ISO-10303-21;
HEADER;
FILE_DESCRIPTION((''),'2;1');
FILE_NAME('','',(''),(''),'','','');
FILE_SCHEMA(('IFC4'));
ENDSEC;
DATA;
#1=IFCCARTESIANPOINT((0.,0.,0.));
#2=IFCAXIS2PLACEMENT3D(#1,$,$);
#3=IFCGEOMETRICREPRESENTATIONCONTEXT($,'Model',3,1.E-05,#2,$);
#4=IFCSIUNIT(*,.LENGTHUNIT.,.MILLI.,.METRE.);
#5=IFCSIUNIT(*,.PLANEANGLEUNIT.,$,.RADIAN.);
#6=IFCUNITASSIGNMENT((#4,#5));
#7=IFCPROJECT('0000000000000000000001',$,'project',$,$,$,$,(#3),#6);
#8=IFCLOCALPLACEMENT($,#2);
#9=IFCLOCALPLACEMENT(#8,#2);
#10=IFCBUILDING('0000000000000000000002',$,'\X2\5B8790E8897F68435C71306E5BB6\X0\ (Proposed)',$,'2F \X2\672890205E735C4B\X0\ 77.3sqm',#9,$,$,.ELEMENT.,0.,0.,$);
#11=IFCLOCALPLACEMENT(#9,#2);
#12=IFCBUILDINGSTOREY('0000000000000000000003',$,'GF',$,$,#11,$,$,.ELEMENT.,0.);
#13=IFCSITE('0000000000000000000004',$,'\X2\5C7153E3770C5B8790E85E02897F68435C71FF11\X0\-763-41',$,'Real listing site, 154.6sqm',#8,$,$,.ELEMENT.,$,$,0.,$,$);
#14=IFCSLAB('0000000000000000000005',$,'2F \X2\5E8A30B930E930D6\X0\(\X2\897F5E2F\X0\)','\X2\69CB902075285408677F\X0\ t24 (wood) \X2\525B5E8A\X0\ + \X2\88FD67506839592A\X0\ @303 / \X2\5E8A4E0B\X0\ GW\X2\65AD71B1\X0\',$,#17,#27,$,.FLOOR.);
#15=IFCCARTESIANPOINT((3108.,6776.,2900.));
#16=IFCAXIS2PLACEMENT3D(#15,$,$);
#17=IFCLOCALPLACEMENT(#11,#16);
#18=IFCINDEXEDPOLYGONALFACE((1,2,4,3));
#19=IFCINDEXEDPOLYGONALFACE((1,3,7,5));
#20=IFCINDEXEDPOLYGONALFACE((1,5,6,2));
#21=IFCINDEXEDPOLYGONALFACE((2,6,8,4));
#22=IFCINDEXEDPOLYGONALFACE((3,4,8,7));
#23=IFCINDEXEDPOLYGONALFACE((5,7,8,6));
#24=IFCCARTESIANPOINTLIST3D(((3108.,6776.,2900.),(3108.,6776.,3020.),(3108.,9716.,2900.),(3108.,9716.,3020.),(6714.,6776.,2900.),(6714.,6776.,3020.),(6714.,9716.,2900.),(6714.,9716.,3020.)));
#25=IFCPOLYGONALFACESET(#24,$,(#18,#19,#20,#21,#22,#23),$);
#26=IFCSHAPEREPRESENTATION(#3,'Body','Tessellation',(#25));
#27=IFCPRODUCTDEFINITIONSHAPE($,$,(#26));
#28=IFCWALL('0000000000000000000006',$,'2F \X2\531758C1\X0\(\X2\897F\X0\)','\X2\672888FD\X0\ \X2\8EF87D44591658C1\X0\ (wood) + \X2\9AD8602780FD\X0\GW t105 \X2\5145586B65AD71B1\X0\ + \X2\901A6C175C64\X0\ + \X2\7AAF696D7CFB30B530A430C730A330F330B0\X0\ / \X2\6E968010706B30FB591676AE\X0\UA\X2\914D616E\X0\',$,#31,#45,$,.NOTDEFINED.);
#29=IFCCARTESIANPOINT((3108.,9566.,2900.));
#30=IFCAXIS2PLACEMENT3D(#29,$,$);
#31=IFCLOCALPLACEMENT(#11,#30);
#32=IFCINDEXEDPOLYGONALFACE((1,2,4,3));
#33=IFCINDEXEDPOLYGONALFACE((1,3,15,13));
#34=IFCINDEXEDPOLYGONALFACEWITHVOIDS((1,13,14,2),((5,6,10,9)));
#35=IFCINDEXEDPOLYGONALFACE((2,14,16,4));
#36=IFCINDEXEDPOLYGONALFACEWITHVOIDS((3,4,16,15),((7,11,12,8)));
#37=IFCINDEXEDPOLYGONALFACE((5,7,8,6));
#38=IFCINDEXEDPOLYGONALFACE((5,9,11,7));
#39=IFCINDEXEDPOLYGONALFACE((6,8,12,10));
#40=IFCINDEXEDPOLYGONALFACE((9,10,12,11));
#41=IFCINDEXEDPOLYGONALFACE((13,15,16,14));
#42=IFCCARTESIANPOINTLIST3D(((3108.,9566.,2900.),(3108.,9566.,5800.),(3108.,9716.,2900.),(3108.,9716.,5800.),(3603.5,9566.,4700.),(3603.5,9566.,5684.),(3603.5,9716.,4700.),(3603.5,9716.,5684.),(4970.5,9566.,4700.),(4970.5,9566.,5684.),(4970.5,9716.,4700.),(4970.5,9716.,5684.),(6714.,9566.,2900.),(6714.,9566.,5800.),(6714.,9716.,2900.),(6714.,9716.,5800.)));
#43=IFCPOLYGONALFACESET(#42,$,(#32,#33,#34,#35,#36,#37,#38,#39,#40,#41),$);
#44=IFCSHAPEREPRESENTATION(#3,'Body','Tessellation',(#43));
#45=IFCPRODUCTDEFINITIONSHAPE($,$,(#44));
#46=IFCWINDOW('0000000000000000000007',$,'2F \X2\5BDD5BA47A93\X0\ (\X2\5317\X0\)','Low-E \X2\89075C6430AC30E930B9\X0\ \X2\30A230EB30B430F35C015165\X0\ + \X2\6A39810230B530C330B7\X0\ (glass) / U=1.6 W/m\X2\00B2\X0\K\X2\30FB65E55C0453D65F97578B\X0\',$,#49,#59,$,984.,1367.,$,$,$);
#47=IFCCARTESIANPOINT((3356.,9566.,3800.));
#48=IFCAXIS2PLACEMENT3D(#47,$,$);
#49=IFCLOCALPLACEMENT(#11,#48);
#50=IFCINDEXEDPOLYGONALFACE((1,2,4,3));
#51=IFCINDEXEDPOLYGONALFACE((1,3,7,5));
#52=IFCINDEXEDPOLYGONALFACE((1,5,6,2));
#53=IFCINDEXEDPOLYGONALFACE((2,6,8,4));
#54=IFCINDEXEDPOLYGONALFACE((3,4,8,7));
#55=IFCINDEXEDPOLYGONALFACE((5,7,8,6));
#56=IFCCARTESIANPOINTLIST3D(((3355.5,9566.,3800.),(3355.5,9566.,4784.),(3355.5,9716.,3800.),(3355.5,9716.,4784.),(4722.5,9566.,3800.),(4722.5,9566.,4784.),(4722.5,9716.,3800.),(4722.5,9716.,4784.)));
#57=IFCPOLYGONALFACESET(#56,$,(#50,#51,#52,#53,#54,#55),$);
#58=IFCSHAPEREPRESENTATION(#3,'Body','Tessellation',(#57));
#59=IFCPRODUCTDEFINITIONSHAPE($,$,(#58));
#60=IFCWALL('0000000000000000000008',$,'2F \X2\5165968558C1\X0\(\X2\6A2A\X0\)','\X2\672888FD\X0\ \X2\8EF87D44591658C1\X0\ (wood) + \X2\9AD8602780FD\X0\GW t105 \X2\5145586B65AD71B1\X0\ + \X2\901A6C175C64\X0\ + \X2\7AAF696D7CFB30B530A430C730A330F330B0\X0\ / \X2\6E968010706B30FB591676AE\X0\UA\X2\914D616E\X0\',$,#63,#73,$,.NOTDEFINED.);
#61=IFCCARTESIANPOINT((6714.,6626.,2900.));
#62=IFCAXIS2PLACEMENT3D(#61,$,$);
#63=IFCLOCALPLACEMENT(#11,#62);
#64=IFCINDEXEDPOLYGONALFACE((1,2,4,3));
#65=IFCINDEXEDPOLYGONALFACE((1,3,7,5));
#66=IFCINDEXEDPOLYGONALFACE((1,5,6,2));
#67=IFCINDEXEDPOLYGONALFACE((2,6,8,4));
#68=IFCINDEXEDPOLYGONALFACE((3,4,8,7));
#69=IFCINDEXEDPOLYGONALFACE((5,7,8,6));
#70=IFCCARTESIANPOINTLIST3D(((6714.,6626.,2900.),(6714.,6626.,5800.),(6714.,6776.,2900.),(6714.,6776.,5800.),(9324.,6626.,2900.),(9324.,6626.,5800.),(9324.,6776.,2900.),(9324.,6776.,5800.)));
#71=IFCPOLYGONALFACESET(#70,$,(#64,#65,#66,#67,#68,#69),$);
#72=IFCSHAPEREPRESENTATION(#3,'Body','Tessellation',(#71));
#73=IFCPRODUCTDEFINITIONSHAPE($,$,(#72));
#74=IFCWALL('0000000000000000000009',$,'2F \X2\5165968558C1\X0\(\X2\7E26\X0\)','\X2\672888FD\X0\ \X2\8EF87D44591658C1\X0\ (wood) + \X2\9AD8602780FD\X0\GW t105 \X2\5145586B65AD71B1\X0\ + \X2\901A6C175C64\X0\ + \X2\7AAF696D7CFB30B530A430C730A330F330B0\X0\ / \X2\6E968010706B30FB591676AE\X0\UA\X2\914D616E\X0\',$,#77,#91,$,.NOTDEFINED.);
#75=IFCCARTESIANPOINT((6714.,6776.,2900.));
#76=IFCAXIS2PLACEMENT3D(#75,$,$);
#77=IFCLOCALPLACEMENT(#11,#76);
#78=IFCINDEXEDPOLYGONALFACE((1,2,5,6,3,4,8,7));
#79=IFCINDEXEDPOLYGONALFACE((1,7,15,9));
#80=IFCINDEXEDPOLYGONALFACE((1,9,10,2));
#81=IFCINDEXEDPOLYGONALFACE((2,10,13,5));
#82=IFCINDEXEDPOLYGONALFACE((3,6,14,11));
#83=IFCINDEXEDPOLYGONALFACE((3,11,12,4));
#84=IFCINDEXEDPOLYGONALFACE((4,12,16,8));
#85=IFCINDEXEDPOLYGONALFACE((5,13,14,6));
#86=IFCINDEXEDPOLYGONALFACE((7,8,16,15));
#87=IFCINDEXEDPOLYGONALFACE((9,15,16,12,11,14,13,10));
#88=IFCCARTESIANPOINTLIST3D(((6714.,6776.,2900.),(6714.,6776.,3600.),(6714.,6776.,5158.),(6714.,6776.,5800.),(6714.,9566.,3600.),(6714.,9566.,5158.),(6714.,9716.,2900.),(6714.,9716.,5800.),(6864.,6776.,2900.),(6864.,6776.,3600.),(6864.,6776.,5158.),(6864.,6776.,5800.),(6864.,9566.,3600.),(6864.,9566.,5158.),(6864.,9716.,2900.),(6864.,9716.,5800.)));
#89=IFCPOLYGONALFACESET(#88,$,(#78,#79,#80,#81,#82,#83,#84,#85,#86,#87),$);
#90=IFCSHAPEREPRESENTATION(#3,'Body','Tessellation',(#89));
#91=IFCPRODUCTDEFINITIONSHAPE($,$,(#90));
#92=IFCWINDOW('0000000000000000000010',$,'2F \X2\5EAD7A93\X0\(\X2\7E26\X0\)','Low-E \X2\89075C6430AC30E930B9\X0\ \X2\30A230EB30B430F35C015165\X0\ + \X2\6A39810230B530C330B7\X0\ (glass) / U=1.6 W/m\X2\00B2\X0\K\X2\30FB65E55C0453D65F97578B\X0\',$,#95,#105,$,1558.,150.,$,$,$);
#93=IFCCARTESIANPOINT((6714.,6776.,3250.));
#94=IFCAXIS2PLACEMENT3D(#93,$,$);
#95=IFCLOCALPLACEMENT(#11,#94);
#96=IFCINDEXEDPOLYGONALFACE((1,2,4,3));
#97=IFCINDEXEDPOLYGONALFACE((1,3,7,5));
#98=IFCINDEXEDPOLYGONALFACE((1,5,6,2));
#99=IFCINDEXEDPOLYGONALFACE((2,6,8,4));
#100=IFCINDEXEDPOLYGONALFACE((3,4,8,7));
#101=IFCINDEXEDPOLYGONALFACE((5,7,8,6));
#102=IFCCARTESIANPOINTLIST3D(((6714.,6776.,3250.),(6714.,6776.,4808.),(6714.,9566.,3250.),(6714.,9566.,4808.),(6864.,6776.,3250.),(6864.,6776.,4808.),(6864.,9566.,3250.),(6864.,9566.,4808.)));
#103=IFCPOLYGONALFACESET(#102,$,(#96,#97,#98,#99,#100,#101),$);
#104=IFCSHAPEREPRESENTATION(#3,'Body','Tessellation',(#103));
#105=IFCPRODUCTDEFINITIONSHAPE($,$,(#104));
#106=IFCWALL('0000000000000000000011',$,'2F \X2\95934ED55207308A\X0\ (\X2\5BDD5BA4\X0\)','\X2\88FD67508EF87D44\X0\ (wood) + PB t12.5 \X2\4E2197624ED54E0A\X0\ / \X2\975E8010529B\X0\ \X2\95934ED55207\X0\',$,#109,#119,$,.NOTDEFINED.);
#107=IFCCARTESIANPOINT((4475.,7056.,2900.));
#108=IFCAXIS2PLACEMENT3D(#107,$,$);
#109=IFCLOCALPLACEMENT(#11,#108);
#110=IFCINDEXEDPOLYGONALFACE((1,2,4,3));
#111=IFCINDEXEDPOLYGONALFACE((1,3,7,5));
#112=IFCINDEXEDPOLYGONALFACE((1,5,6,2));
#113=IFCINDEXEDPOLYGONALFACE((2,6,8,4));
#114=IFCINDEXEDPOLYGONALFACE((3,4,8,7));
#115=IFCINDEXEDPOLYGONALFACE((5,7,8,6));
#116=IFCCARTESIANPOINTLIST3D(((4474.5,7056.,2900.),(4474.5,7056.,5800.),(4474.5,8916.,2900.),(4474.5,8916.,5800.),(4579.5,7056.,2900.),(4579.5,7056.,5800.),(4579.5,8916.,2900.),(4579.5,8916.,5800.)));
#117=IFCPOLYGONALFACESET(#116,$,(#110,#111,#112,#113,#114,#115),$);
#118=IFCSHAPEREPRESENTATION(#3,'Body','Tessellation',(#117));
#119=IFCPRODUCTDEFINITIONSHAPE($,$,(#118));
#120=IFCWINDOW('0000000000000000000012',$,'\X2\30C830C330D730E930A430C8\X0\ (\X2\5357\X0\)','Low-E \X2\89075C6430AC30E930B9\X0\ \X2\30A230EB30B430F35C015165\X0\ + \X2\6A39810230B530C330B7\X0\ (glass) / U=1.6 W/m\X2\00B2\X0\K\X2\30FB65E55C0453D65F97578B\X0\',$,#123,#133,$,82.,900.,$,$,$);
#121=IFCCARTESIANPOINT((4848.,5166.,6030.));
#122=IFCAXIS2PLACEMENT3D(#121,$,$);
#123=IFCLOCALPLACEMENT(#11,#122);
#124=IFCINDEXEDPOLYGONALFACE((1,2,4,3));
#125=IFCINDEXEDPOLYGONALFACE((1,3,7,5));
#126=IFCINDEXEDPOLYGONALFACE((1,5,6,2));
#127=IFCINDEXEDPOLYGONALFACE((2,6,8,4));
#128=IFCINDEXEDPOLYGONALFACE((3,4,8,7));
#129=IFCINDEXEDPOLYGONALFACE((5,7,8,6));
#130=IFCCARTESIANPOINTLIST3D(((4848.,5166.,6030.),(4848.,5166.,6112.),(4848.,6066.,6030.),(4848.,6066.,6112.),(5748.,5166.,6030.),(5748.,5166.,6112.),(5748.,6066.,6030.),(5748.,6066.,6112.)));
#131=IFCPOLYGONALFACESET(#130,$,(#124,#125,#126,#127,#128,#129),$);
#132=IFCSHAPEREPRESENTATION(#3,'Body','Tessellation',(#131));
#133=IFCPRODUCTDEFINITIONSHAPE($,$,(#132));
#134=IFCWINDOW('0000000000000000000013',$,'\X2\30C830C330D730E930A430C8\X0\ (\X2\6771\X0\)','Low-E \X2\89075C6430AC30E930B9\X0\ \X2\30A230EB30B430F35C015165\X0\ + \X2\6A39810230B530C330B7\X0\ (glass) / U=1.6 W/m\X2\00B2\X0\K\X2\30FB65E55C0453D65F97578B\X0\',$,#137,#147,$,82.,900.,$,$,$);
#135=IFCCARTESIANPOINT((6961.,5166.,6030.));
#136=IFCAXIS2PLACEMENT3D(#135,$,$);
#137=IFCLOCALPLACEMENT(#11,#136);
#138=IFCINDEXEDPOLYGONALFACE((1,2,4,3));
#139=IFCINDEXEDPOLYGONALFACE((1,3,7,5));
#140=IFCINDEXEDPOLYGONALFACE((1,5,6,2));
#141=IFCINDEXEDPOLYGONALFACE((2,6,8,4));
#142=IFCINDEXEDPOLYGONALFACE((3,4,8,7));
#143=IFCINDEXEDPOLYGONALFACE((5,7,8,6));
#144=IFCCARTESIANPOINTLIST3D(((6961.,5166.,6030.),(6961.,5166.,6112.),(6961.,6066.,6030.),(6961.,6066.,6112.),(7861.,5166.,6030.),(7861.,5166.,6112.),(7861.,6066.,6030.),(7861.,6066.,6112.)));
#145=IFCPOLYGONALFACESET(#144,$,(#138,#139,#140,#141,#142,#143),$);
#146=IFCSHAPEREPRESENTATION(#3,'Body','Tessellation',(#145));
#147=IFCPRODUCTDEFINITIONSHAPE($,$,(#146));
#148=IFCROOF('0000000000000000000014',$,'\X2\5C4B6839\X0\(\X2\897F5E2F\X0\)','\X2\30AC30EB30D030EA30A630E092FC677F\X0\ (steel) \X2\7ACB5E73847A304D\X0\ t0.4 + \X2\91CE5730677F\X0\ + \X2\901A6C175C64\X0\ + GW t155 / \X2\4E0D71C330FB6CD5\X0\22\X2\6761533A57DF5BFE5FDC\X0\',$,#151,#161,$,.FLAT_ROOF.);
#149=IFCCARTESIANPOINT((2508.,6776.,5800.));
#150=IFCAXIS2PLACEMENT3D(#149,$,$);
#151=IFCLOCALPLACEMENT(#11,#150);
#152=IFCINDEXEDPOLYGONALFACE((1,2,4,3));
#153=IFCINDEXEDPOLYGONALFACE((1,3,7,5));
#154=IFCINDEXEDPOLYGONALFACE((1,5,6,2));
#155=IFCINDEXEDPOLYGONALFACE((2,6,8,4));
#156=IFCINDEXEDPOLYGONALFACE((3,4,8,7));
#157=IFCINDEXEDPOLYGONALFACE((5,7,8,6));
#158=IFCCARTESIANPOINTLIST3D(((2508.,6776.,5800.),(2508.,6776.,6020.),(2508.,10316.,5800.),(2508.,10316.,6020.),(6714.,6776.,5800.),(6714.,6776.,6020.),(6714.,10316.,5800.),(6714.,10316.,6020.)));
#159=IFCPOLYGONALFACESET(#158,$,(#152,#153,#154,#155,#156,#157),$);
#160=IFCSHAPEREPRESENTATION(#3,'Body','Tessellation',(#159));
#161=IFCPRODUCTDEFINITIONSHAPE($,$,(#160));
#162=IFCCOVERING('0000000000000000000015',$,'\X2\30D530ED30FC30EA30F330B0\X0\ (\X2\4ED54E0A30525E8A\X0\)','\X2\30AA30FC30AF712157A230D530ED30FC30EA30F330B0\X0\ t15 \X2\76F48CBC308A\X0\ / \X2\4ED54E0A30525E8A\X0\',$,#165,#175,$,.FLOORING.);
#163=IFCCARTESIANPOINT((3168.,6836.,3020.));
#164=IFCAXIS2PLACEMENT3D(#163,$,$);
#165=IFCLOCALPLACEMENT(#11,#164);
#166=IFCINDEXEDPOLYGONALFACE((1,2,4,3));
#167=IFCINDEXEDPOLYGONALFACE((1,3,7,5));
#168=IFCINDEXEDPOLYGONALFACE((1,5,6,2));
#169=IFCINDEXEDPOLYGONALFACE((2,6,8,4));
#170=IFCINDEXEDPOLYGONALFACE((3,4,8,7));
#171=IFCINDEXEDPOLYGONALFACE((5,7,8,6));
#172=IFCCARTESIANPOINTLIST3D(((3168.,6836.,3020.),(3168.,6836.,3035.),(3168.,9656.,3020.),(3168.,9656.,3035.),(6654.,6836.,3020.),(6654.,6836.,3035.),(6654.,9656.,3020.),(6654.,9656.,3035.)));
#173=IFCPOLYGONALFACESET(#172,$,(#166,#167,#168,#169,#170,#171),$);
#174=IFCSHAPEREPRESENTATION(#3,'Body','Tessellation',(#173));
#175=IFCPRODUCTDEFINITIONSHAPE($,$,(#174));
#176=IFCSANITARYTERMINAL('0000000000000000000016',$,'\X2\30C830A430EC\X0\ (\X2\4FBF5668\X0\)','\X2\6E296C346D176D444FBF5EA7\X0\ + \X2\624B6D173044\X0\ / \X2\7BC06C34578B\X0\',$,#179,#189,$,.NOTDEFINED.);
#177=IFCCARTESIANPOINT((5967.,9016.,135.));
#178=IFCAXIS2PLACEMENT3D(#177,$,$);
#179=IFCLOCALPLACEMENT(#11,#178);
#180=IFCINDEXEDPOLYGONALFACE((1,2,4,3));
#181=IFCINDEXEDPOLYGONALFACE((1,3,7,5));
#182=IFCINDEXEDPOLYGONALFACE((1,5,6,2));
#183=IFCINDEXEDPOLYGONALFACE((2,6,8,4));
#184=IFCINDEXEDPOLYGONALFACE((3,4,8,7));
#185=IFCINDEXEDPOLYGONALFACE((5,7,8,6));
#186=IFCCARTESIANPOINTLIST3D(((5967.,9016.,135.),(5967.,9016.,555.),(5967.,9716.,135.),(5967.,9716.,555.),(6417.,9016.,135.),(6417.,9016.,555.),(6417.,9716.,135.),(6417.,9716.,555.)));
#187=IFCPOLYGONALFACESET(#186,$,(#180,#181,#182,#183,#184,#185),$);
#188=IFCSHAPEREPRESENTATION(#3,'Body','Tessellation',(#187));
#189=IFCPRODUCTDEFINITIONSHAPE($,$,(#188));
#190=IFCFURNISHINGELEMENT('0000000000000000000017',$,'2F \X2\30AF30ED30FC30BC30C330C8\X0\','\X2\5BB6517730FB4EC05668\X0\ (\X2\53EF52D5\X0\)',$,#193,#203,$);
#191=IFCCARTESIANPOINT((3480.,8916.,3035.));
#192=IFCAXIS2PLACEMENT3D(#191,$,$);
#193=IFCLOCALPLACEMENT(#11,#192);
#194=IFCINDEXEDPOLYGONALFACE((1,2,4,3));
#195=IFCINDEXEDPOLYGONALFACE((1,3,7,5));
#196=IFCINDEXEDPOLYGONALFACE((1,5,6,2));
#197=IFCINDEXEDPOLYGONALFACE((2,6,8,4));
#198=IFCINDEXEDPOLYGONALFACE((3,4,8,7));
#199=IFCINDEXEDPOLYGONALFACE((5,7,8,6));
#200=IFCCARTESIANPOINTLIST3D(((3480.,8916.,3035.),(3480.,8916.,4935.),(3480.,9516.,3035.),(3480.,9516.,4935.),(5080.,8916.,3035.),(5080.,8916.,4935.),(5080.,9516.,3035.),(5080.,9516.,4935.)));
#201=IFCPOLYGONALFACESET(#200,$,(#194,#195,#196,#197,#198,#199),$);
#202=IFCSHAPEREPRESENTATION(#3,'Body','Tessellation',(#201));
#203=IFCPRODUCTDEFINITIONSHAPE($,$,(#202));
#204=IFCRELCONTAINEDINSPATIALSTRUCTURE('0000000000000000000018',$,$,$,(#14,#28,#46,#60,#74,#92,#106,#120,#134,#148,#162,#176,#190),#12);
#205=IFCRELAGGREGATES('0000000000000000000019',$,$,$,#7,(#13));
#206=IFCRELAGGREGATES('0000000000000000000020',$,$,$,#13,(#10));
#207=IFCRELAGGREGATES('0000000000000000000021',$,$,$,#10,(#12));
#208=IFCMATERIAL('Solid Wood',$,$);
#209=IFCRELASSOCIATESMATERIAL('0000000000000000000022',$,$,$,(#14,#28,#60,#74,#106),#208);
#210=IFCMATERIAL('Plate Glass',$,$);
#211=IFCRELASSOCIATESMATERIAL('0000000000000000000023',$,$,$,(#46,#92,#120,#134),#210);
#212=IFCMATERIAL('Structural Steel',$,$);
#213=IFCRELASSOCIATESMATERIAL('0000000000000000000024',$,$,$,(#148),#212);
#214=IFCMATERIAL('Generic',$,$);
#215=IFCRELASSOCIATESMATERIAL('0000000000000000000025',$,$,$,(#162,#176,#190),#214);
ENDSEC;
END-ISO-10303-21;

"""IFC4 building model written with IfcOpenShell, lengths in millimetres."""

from ifc_helpers import new_model, si_unit, frame, frame_2d, origin, place, context, project, spatial, rectangle, extrude, material, element, fill, save


model = new_model("IFC4")

# Units and contexts
model_context = context("Model", 3, precision=1e-05, world=origin())
ifc_project = project(units=[si_unit("LENGTHUNIT", "METRE", prefix="MILLI"), si_unit("PLANEANGLEUNIT", "RADIAN")], contexts=[model_context])

# Site, building, storey
site_placement = place(None, origin())
site = spatial("IfcSite", under=ifc_project, at=site_placement, Name="山口県宇部市西桃山１-763-41", ObjectType="Real listing site, 154.6sqm", CompositionType="ELEMENT", RefElevation=0.0)
building_placement = place(site_placement, origin())
building = spatial("IfcBuilding", under=site, at=building_placement, Name="宇部西桃山の家 (Proposed)", ObjectType="2F 木造平屋 77.3sqm", CompositionType="ELEMENT", ElevationOfRefHeight=0.0, ElevationOfTerrain=0.0)
storey_placement = place(building_placement, origin())
storey = spatial("IfcBuildingStorey", under=building, at=storey_placement, Name="GF", CompositionType="ELEMENT", Elevation=0.0)

# Slab
ifc_material_1 = material(Name="Solid Wood")
slab_placement = place(storey_placement, frame((3108.0, 6776.0, 2900.0)))
element("IfcSlab", 1, at=slab_placement, inside=storey, material=ifc_material_1, Name="2F 床スラブ(西帯)", Description="構造用合板 t24 (wood) 剛床 + 製材根太 @303 / 床下 GW断熱", PredefinedType="FLOOR", context=model_context, shape_type="SweptSolid", body=[
    extrude(rectangle(XDim=3606.0, YDim=2940.0, at=frame_2d((1803.0, 1470.0))), frame((3108.0, 6776.0, 2900.0)), (0.0, 0.0, 1.0), 120.0),
])

# Wall, opening, window
wall_1_placement = place(storey_placement, frame((3108.0, 9566.0, 2900.0)))
wall_1 = element("IfcWall", 2, at=wall_1_placement, inside=storey, material=ifc_material_1, Name="2F 北壁(西)", Description="木製 軸組外壁 (wood) + 高性能GW t105 充填断熱 + 通気層 + 窯業系サイディング / 準耐火・外皮UA配慮", PredefinedType="NOTDEFINED", context=model_context, shape_type="SweptSolid", body=[
    extrude(rectangle(XDim=3606.0, YDim=150.0, at=frame_2d((1803.0, 75.0))), frame((3108.0, 9566.0, 2900.0)), (0.0, 0.0, 1.0), 2900.0),
])
opening_1_placement = place(storey_placement, frame((3356.0, 9566.0, 3800.0)))
opening_1 = element("IfcOpeningElement", 3, at=opening_1_placement, cuts=wall_1, PredefinedType="NOTDEFINED", context=model_context, shape_type="SweptSolid", body=[
    extrude(rectangle(XDim=1367.0, YDim=150.0, at=frame_2d((683.0, 75.0))), frame((3356.0, 9566.0, 3800.0)), (0.0, 0.0, 1.0), 984.0),
])
ifc_material_2 = material(Name="Plate Glass")
window_1_placement = place(storey_placement, frame((3356.0, 9566.0, 3800.0)))
window_1 = element("IfcWindow", 4, at=window_1_placement, inside=storey, material=ifc_material_2, Name="2F 寝室窓 (北)", Description="Low-E 複層ガラス アルゴン封入 + 樹脂サッシ (glass) / U=1.6 W/m²K・日射取得型", OverallHeight=984.0, OverallWidth=1367.0, context=model_context, shape_type="SweptSolid", body=[
    extrude(rectangle(XDim=1367.0, YDim=150.0, at=frame_2d((683.0, 75.0))), frame((3356.0, 9566.0, 3800.0)), (0.0, 0.0, 1.0), 984.0),
])
fill(opening_1, window_1)

# Wall
wall_2_placement = place(storey_placement, frame((6714.0, 6626.0, 2900.0)))
element("IfcWall", 5, at=wall_2_placement, inside=storey, material=ifc_material_1, Name="2F 入隅壁(横)", Description="木製 軸組外壁 (wood) + 高性能GW t105 充填断熱 + 通気層 + 窯業系サイディング / 準耐火・外皮UA配慮", PredefinedType="NOTDEFINED", context=model_context, shape_type="SweptSolid", body=[
    extrude(rectangle(XDim=2610.0, YDim=150.0, at=frame_2d((1305.0, 75.0))), frame((6714.0, 6626.0, 2900.0)), (0.0, 0.0, 1.0), 2900.0),
])

# Wall, opening, window
wall_3_placement = place(storey_placement, frame((6714.0, 6776.0, 2900.0)))
wall_3 = element("IfcWall", 6, at=wall_3_placement, inside=storey, material=ifc_material_1, Name="2F 入隅壁(縦)", Description="木製 軸組外壁 (wood) + 高性能GW t105 充填断熱 + 通気層 + 窯業系サイディング / 準耐火・外皮UA配慮", PredefinedType="NOTDEFINED", context=model_context, shape_type="SweptSolid", body=[
    extrude(rectangle(XDim=150.0, YDim=2940.0, at=frame_2d((75.0, 1470.0))), frame((6714.0, 6776.0, 2900.0)), (0.0, 0.0, 1.0), 2900.0),
])
opening_2_placement = place(storey_placement, frame((6714.0, 6776.0, 3250.0)))
opening_2 = element("IfcOpeningElement", 7, at=opening_2_placement, cuts=wall_3, PredefinedType="NOTDEFINED", context=model_context, shape_type="SweptSolid", body=[
    extrude(rectangle(XDim=150.0, YDim=2790.0, at=frame_2d((75.0, 1395.0))), frame((6714.0, 6776.0, 3250.0)), (0.0, 0.0, 1.0), 1558.0),
])
window_2_placement = place(storey_placement, frame((6714.0, 6776.0, 3250.0)))
window_2 = element("IfcWindow", 8, at=window_2_placement, inside=storey, material=ifc_material_2, Name="2F 庭窓(縦)", Description="Low-E 複層ガラス アルゴン封入 + 樹脂サッシ (glass) / U=1.6 W/m²K・日射取得型", OverallHeight=1558.0, OverallWidth=150.0, context=model_context, shape_type="SweptSolid", body=[
    extrude(rectangle(XDim=150.0, YDim=2790.0, at=frame_2d((75.0, 1395.0))), frame((6714.0, 6776.0, 3250.0)), (0.0, 0.0, 1.0), 1558.0),
])
fill(opening_2, window_2)

# Wall
wall_4_placement = place(storey_placement, frame((4475.0, 7056.0, 2900.0)))
element("IfcWall", 9, at=wall_4_placement, inside=storey, material=ifc_material_1, Name="2F 間仕切り (寝室)", Description="製材軸組 (wood) + PB t12.5 両面仕上 / 非耐力 間仕切", PredefinedType="NOTDEFINED", context=model_context, shape_type="SweptSolid", body=[
    extrude(rectangle(XDim=105.0, YDim=1860.0, at=frame_2d((52.0, 930.0))), frame((4475.0, 7056.0, 2900.0)), (0.0, 0.0, 1.0), 2900.0),
])

# Windows
window_3_placement = place(storey_placement, frame((4848.0, 5166.0, 6030.0)))
element("IfcWindow", 10, at=window_3_placement, inside=storey, material=ifc_material_2, Name="トップライト (南)", Description="Low-E 複層ガラス アルゴン封入 + 樹脂サッシ (glass) / U=1.6 W/m²K・日射取得型", OverallHeight=82.0, OverallWidth=900.0, context=model_context, shape_type="SweptSolid", body=[
    extrude(rectangle(XDim=900.0, YDim=900.0, at=frame_2d((450.0, 450.0))), frame((4848.0, 5166.0, 6030.0)), (0.0, 0.0, 1.0), 82.0),
])
window_4_placement = place(storey_placement, frame((6961.0, 5166.0, 6030.0)))
element("IfcWindow", 11, at=window_4_placement, inside=storey, material=ifc_material_2, Name="トップライト (東)", Description="Low-E 複層ガラス アルゴン封入 + 樹脂サッシ (glass) / U=1.6 W/m²K・日射取得型", OverallHeight=82.0, OverallWidth=900.0, context=model_context, shape_type="SweptSolid", body=[
    extrude(rectangle(XDim=900.0, YDim=900.0, at=frame_2d((450.0, 450.0))), frame((6961.0, 5166.0, 6030.0)), (0.0, 0.0, 1.0), 82.0),
])

# Roof
ifc_material_3 = material(Name="Structural Steel")
for number, where, name in (
    (12, (2508.0, 6776.0, 5800.0), "屋根(西帯)"),
):
    element("IfcRoof", number, at=place(storey_placement, frame(where)), inside=storey, material=ifc_material_3, Name=name, Description="ガルバリウム鋼板 (steel) 立平葺き t0.4 + 野地板 + 通気層 + GW t155 / 不燃・法22条区域対応", PredefinedType="FLAT_ROOF", context=model_context, shape_type="SweptSolid", body=[
        extrude(rectangle(XDim=4206.0, YDim=3540.0, at=frame_2d((2103.0, 1770.0))), frame((2508.0, 6776.0, 5800.0)), (0.0, 0.0, 1.0), 220.0),
    ])

# Covering
ifc_material_4 = material(Name="Generic")
covering_placement = place(storey_placement, frame((3168.0, 6836.0, 3020.0)))
element("IfcCovering", 13, at=covering_placement, inside=storey, material=ifc_material_4, Name="フローリング (仕上げ床)", Description="オーク無垢フローリング t15 直貼り / 仕上げ床", PredefinedType="FLOORING", context=model_context, shape_type="SweptSolid", body=[
    extrude(rectangle(XDim=3486.0, YDim=2820.0, at=frame_2d((1743.0, 1410.0))), frame((3168.0, 6836.0, 3020.0)), (0.0, 0.0, 1.0), 15.0),
])

# Sanitary terminal
sanitary_terminal_placement = place(storey_placement, frame((5967.0, 9016.0, 135.0)))
element("IfcSanitaryTerminal", 14, at=sanitary_terminal_placement, inside=storey, material=ifc_material_4, Name="トイレ (便器)", Description="温水洗浄便座 + 手洗い / 節水型", PredefinedType="NOTDEFINED", context=model_context, shape_type="SweptSolid", body=[
    extrude(rectangle(XDim=450.0, YDim=700.0, at=frame_2d((225.0, 350.0))), frame((5967.0, 9016.0, 135.0)), (0.0, 0.0, 1.0), 420.0),
])

# Furnishing element
furnishing_1_placement = place(storey_placement, frame((3480.0, 8916.0, 3035.0)))
element("IfcFurnishingElement", 15, at=furnishing_1_placement, inside=storey, material=ifc_material_4, Name="2F クローゼット", Description="家具・什器 (可動)", context=model_context, shape_type="SweptSolid", body=[
    extrude(rectangle(XDim=1600.0, YDim=600.0, at=frame_2d((800.0, 300.0))), frame((3480.0, 8916.0, 3035.0)), (0.0, 0.0, 1.0), 1900.0),
])

save(model, "model.ifc")
